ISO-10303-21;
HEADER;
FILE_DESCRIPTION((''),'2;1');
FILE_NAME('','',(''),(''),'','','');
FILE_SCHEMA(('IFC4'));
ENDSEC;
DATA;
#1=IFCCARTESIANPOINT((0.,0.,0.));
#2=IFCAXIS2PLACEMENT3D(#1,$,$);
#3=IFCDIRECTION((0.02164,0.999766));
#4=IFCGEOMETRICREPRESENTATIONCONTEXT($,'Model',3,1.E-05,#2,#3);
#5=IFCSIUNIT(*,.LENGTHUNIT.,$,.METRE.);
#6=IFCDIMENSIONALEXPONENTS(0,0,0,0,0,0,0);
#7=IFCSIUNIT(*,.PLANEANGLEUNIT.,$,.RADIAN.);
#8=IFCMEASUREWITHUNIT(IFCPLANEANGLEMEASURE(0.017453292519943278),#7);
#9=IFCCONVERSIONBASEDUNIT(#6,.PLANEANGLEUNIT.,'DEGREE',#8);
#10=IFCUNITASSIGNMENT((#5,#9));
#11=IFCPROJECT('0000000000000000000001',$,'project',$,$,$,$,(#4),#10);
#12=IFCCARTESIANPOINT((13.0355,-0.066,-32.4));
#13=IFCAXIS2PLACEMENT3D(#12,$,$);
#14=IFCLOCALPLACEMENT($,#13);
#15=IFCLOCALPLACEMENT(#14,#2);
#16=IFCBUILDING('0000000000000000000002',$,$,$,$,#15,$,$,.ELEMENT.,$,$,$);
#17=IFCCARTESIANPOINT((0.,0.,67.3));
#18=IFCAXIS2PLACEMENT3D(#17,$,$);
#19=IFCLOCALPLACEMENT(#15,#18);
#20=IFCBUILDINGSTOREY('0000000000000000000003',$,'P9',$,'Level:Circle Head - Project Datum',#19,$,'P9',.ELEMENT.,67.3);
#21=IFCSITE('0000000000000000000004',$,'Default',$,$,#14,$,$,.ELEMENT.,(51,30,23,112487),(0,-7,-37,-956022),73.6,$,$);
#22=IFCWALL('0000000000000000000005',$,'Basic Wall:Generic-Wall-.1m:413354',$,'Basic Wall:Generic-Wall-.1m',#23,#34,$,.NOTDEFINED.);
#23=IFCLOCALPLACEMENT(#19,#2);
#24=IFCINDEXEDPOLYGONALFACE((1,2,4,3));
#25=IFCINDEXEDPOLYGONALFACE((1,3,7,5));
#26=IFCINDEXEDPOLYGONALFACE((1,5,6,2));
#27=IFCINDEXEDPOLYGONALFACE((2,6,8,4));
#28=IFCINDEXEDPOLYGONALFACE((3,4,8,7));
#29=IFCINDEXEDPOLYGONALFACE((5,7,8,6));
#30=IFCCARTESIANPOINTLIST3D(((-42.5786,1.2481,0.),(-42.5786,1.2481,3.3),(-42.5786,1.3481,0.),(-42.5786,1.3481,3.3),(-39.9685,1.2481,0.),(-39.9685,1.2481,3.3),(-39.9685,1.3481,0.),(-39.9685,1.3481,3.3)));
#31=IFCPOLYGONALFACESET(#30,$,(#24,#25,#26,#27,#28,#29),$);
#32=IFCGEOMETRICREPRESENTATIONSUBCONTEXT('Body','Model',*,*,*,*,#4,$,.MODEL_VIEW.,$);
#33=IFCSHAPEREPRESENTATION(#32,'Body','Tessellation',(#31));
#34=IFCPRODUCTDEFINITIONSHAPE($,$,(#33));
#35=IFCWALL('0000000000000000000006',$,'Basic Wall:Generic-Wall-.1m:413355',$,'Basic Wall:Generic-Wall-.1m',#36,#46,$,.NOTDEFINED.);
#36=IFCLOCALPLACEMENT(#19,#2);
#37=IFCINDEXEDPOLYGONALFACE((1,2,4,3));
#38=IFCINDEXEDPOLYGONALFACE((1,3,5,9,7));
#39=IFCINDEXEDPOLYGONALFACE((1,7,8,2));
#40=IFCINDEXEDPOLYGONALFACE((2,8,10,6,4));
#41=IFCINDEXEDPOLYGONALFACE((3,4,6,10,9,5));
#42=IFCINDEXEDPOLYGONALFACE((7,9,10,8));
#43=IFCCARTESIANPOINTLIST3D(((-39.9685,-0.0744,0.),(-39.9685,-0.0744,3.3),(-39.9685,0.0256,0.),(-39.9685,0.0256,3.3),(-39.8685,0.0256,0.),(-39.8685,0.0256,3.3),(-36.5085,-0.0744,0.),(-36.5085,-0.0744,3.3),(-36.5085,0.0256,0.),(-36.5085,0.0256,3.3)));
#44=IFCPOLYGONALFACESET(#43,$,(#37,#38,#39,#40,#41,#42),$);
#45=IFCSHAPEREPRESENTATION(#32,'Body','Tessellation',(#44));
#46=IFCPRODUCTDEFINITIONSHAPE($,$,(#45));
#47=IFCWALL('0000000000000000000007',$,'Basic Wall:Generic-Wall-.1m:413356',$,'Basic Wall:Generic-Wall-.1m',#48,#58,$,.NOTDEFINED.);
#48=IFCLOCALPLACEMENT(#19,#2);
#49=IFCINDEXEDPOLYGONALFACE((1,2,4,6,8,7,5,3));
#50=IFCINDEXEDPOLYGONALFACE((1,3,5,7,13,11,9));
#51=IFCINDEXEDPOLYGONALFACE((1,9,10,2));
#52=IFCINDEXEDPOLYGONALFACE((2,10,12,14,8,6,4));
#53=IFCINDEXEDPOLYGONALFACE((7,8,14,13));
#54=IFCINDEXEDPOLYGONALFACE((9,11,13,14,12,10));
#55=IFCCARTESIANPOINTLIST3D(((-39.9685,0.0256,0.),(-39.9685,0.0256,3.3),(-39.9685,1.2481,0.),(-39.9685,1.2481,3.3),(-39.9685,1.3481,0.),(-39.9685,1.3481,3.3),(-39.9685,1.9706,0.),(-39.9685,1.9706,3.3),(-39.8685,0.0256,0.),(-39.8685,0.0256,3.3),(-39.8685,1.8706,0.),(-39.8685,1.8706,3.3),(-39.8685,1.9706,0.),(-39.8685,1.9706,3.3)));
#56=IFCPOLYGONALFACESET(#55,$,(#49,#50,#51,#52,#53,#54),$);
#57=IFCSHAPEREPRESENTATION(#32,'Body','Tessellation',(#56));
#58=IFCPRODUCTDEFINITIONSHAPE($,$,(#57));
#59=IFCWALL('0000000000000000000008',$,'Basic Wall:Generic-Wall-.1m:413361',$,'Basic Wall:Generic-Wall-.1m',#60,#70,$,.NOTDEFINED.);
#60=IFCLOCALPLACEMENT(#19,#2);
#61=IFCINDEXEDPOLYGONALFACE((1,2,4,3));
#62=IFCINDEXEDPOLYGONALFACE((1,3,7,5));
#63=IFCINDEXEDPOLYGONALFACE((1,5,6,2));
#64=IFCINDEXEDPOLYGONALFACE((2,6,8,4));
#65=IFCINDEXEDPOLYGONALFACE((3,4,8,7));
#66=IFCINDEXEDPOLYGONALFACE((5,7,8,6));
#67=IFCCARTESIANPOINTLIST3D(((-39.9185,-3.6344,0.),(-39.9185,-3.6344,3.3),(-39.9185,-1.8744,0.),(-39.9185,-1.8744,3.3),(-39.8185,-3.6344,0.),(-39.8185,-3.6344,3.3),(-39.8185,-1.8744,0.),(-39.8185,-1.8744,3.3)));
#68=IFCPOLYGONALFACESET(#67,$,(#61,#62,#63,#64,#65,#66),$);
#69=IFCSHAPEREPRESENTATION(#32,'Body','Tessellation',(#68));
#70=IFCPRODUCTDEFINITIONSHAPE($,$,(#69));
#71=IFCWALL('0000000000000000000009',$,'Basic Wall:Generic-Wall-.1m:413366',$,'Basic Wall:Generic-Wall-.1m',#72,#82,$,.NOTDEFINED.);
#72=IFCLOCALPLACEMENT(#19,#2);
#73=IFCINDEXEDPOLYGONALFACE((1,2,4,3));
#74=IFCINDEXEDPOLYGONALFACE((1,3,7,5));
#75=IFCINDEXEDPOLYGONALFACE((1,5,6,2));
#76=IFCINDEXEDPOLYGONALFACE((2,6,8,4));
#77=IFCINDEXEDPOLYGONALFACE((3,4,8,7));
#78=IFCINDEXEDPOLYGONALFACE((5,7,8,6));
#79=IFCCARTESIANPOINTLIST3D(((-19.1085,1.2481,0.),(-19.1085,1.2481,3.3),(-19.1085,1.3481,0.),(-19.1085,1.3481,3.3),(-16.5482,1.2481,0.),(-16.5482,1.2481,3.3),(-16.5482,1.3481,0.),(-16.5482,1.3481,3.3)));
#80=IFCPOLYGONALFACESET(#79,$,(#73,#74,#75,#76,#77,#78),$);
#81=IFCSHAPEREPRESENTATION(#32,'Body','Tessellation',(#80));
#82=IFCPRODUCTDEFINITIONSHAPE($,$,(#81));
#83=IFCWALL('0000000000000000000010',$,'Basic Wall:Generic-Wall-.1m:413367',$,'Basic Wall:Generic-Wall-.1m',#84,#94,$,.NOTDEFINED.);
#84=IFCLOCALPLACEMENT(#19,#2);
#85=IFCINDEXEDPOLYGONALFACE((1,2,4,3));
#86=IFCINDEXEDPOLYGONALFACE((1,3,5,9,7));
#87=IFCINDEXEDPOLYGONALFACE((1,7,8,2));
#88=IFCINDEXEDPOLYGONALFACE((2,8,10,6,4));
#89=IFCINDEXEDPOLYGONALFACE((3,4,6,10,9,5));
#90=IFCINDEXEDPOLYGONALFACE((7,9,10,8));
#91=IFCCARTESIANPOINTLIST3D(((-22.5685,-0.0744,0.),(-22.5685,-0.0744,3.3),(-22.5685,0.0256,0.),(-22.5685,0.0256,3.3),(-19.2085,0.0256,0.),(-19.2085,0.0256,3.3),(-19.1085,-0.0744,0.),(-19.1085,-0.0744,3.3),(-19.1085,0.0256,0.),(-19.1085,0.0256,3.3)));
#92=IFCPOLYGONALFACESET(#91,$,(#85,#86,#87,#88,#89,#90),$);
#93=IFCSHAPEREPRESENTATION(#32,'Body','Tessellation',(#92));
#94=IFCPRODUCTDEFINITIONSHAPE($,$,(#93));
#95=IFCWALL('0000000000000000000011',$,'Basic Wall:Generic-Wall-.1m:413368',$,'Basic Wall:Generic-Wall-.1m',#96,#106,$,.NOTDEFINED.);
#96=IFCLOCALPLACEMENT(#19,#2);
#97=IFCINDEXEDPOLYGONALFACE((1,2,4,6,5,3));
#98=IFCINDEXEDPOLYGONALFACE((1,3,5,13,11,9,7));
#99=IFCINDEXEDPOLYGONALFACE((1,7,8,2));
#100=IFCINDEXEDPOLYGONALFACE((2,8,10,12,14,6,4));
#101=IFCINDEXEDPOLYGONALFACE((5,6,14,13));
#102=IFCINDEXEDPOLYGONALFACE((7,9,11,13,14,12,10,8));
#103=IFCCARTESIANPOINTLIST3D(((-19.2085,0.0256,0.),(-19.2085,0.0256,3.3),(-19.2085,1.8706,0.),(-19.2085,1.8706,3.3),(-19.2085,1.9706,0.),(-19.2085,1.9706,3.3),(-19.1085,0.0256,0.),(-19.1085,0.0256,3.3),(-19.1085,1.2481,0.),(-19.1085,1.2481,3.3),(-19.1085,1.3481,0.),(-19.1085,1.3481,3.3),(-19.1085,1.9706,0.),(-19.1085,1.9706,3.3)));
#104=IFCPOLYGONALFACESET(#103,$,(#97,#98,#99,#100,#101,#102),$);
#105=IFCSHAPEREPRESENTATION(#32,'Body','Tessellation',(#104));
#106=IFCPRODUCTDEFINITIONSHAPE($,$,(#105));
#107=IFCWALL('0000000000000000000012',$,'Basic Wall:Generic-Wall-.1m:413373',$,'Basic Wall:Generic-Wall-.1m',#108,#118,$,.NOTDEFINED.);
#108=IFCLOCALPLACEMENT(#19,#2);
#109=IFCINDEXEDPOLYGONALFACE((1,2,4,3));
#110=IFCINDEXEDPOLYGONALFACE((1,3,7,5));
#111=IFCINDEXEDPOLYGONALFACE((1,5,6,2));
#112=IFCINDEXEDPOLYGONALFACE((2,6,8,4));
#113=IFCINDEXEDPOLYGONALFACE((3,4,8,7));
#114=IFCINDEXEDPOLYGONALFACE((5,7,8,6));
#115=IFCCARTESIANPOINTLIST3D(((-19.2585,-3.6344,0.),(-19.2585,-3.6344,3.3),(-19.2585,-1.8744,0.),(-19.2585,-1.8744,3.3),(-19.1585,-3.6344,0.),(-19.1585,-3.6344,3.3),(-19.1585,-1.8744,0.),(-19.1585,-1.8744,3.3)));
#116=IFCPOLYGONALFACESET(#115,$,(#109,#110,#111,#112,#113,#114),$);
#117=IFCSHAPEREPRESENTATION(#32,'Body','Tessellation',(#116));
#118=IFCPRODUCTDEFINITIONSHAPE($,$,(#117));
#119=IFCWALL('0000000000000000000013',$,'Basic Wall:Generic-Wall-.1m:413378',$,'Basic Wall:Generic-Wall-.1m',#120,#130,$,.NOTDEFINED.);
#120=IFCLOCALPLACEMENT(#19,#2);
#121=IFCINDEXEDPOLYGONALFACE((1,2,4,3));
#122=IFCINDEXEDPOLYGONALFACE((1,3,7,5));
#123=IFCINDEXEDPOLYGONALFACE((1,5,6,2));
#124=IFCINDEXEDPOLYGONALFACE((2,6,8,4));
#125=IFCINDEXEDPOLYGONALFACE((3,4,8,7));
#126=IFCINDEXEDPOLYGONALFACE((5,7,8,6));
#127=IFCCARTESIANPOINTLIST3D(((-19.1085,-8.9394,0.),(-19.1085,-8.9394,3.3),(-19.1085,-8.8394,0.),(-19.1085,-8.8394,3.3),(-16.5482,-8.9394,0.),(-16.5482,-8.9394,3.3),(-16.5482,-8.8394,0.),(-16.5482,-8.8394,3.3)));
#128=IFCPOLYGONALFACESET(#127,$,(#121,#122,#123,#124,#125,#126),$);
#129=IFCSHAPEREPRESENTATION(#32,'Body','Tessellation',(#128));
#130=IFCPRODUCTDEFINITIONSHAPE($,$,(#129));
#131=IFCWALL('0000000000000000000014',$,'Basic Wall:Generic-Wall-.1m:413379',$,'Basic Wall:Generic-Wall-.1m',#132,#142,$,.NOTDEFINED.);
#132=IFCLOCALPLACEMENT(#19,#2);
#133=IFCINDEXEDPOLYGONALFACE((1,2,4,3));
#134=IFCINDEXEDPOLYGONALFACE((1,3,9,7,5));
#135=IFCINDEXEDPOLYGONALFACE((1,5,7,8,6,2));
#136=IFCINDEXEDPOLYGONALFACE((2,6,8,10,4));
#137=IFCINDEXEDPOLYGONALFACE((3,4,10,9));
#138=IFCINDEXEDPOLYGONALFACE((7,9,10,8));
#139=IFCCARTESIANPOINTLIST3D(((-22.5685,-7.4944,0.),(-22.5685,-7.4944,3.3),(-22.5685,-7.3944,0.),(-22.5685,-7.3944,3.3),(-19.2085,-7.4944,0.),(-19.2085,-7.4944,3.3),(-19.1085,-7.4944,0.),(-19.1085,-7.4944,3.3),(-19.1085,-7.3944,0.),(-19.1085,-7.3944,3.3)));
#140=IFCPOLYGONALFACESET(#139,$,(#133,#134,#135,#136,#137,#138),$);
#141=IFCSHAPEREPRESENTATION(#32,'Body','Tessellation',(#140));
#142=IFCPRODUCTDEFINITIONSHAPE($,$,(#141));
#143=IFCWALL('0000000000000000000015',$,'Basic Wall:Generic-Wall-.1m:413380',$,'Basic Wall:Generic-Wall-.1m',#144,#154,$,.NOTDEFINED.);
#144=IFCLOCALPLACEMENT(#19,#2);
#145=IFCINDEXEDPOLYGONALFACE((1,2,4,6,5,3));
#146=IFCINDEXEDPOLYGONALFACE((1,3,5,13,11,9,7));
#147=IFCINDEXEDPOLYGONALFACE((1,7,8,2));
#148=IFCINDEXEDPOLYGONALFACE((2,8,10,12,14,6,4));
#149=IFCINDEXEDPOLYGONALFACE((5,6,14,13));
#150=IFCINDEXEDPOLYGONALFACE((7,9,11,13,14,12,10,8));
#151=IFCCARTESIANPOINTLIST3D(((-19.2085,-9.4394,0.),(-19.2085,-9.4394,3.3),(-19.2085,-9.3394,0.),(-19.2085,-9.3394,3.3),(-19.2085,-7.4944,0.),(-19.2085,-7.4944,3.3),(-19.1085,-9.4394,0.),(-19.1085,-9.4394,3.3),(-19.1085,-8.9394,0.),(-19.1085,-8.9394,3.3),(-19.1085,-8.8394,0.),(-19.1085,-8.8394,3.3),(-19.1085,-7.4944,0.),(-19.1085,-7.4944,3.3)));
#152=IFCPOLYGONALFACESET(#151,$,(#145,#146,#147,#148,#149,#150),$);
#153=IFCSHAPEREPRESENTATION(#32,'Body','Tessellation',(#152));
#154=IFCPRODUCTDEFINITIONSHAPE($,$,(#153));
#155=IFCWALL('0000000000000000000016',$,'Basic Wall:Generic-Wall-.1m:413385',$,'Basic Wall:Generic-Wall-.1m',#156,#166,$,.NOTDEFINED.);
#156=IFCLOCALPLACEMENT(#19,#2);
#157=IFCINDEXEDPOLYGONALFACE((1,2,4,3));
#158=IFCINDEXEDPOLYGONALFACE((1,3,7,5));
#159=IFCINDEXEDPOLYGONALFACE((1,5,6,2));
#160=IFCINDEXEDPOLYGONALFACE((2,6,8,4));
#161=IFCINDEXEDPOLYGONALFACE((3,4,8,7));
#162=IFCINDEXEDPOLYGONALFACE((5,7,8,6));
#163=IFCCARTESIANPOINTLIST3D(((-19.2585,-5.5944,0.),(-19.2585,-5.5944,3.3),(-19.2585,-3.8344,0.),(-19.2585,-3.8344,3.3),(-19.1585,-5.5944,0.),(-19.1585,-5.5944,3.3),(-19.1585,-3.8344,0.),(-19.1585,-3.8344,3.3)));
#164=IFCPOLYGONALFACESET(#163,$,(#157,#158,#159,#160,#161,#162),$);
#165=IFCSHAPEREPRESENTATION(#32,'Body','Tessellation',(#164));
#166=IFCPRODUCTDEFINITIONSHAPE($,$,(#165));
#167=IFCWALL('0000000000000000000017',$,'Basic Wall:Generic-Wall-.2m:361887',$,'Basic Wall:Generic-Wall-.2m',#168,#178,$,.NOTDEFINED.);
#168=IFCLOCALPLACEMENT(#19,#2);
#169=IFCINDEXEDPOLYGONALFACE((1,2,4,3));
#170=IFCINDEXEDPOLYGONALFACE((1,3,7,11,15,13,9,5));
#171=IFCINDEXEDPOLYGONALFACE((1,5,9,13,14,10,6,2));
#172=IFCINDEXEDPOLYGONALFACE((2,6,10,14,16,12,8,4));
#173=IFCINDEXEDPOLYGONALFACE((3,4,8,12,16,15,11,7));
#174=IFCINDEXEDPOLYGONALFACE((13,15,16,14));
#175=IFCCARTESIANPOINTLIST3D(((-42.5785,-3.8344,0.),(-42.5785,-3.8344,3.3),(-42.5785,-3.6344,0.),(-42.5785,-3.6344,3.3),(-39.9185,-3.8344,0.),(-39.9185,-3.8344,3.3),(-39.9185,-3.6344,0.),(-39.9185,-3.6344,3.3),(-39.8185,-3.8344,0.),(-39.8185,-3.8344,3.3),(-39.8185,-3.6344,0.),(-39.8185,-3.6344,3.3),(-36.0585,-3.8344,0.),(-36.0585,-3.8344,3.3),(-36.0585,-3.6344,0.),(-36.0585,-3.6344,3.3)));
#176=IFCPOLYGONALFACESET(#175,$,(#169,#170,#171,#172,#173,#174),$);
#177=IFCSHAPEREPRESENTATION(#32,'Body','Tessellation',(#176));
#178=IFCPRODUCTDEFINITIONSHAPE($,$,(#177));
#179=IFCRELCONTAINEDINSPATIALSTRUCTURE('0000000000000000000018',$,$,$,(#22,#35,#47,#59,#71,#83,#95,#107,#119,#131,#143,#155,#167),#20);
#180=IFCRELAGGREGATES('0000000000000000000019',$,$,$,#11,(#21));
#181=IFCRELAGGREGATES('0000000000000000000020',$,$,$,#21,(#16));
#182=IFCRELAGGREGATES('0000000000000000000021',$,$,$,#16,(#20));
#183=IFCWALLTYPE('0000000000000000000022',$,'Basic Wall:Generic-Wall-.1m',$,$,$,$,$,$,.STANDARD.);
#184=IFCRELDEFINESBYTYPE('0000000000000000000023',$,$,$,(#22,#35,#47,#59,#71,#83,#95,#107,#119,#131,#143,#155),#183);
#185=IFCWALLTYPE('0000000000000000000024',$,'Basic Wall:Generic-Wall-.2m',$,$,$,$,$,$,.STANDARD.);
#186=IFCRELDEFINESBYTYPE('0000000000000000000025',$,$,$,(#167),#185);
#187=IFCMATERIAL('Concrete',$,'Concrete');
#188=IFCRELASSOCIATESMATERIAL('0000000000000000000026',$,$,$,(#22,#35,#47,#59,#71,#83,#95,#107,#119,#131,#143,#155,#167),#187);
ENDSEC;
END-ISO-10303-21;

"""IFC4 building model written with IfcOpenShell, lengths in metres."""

from ifc_helpers import new_model, entity, si_unit, converted_unit, direction, frame, origin, place, context, subcontext, project, spatial, indexed_curve, outline, extrude, material, type_object, element, save


model = new_model("IFC4")

# Units and contexts
model_context = context("Model", 3, precision=1e-05, world=origin(), true_north=direction((0.02164, 0.999766)))
body_context = subcontext(model_context, "Body", "Model", "MODEL_VIEW")
ifc_project = project(units=[si_unit("LENGTHUNIT", "METRE"), converted_unit("PLANEANGLEUNIT", "DEGREE", entity("IfcPlaneAngleMeasure", 0.017453292519943278), si_unit("PLANEANGLEUNIT", "RADIAN"), dimensions=[0, 0, 0, 0, 0, 0, 0])], contexts=[model_context])

# Site, building, storey
site_placement = place(None, frame((13.0355, -0.066, -32.4)))
site = spatial("IfcSite", under=ifc_project, at=site_placement, Name="Default", CompositionType="ELEMENT", RefLatitude=(51, 30, 23, 112487), RefLongitude=(0, -7, -37, -956022), RefElevation=73.6)
building_placement = place(site_placement, origin())
building = spatial("IfcBuilding", under=site, at=building_placement, CompositionType="ELEMENT")
storey_placement = place(building_placement, frame((0.0, 0.0, 67.3)))
storey = spatial("IfcBuildingStorey", under=building, at=storey_placement, Name="P9", ObjectType="Level:Circle Head - Project Datum", LongName="P9", CompositionType="ELEMENT", Elevation=67.3)

# Shared definitions
ifc_material = material(Name="Concrete", Category="Concrete")

# Walls
wall_type_1 = type_object("IfcWallType", Name="Basic Wall:Generic-Wall-.1m", PredefinedType="STANDARD")
wall_1_placement = place(storey_placement, frame((-39.9685, 1.2981, 0.0), z_axis=(0.0, 0.0, 1.0), x_axis=(-1.0, 0.0, 0.0)))
element("IfcWall", 1, at=wall_1_placement, inside=storey, type_object=wall_type_1, material=ifc_material, Name="Basic Wall:Generic-Wall-.1m:413354", ObjectType="Basic Wall:Generic-Wall-.1m", PredefinedType="NOTDEFINED", context=body_context, shape_type="SweptSolid", body=[
    extrude(outline(indexed_curve([(2.6101, -0.05), (2.6101, 0.05), (0.0, 0.05), (0.0, -0.05), (2.6101, -0.05)], self_intersect=False)), origin(), (0.0, 0.0, 1.0), 3.3),
])
wall_2_placement = place(storey_placement, frame((-36.5085, -0.0244, 0.0), z_axis=(0.0, 0.0, 1.0), x_axis=(-1.0, 0.0, 0.0)))
element("IfcWall", 2, at=wall_2_placement, inside=storey, type_object=wall_type_1, material=ifc_material, Name="Basic Wall:Generic-Wall-.1m:413355", ObjectType="Basic Wall:Generic-Wall-.1m", PredefinedType="NOTDEFINED", context=body_context, shape_type="SweptSolid", body=[
    extrude(outline(indexed_curve([(3.46, -0.05), (3.46, 0.05), (0.0, 0.05), (0.0, -0.05), (3.36, -0.05), (3.46, -0.05)], self_intersect=False)), origin(), (0.0, 0.0, 1.0), 3.3),
])
wall_3_placement = place(storey_placement, frame((-39.9185, 0.0256, 0.0), z_axis=(0.0, 0.0, 1.0), x_axis=(0.0, 1.0, 0.0)))
element("IfcWall", 3, at=wall_3_placement, inside=storey, type_object=wall_type_1, material=ifc_material, Name="Basic Wall:Generic-Wall-.1m:413356", ObjectType="Basic Wall:Generic-Wall-.1m", PredefinedType="NOTDEFINED", context=body_context, shape_type="SweptSolid", body=[
    extrude(outline(indexed_curve([(1.945, -0.05), (1.945, 0.05), (1.3225, 0.05), (1.2225, 0.05), (0.0, 0.05), (0.0, -0.05), (1.845, -0.05), (1.945, -0.05)], self_intersect=False)), origin(), (0.0, 0.0, 1.0), 3.3),
])
wall_4_placement = place(storey_placement, frame((-39.8685, -1.8744, 0.0), z_axis=(0.0, 0.0, 1.0), x_axis=(0.0, -1.0, 0.0)))
element("IfcWall", 4, at=wall_4_placement, inside=storey, type_object=wall_type_1, material=ifc_material, Name="Basic Wall:Generic-Wall-.1m:413361", ObjectType="Basic Wall:Generic-Wall-.1m", PredefinedType="NOTDEFINED", context=body_context, shape_type="SweptSolid", body=[
    extrude(outline(indexed_curve([(1.76, -0.05), (1.76, 0.05), (0.0, 0.05), (0.0, -0.05), (1.76, -0.05)], self_intersect=False)), origin(), (0.0, 0.0, 1.0), 3.3),
])
wall_5_placement = place(storey_placement, frame((-19.1085, 1.2981, 0.0)))
element("IfcWall", 5, at=wall_5_placement, inside=storey, type_object=wall_type_1, material=ifc_material, Name="Basic Wall:Generic-Wall-.1m:413366", ObjectType="Basic Wall:Generic-Wall-.1m", PredefinedType="NOTDEFINED", context=body_context, shape_type="SweptSolid", body=[
    extrude(outline(indexed_curve([(2.5602, -0.05), (2.5602, 0.05), (0.0, 0.05), (0.0, -0.05), (2.5602, -0.05)], self_intersect=False)), origin(), (0.0, 0.0, 1.0), 3.3),
])
wall_6_placement = place(storey_placement, frame((-22.5685, -0.0244, 0.0)))
element("IfcWall", 6, at=wall_6_placement, inside=storey, type_object=wall_type_1, material=ifc_material, Name="Basic Wall:Generic-Wall-.1m:413367", ObjectType="Basic Wall:Generic-Wall-.1m", PredefinedType="NOTDEFINED", context=body_context, shape_type="SweptSolid", body=[
    extrude(outline(indexed_curve([(3.46, -0.05), (3.46, 0.05), (3.36, 0.05), (0.0, 0.05), (0.0, -0.05), (3.46, -0.05)], self_intersect=False)), origin(), (0.0, 0.0, 1.0), 3.3),
])
wall_7_placement = place(storey_placement, frame((-19.1585, 0.0256, 0.0), z_axis=(0.0, 0.0, 1.0), x_axis=(0.0, 1.0, 0.0)))
element("IfcWall", 7, at=wall_7_placement, inside=storey, type_object=wall_type_1, material=ifc_material, Name="Basic Wall:Generic-Wall-.1m:413368", ObjectType="Basic Wall:Generic-Wall-.1m", PredefinedType="NOTDEFINED", context=body_context, shape_type="SweptSolid", body=[
    extrude(outline(indexed_curve([(1.945, -0.05), (1.945, 0.05), (1.845, 0.05), (0.0, 0.05), (0.0, -0.05), (1.2225, -0.05), (1.3225, -0.05), (1.945, -0.05)], self_intersect=False)), origin(), (0.0, 0.0, 1.0), 3.3),
])
wall_8_placement = place(storey_placement, frame((-19.2085, -1.8744, 0.0), z_axis=(0.0, 0.0, 1.0), x_axis=(0.0, -1.0, 0.0)))
element("IfcWall", 8, at=wall_8_placement, inside=storey, type_object=wall_type_1, material=ifc_material, Name="Basic Wall:Generic-Wall-.1m:413373", ObjectType="Basic Wall:Generic-Wall-.1m", PredefinedType="NOTDEFINED", context=body_context, shape_type="SweptSolid", body=[
    extrude(outline(indexed_curve([(1.76, -0.05), (1.76, 0.05), (0.0, 0.05), (0.0, -0.05), (1.76, -0.05)], self_intersect=False)), origin(), (0.0, 0.0, 1.0), 3.3),
])
wall_9_placement = place(storey_placement, frame((-19.1085, -8.8894, 0.0)))
element("IfcWall", 9, at=wall_9_placement, inside=storey, type_object=wall_type_1, material=ifc_material, Name="Basic Wall:Generic-Wall-.1m:413378", ObjectType="Basic Wall:Generic-Wall-.1m", PredefinedType="NOTDEFINED", context=body_context, shape_type="SweptSolid", body=[
    extrude(outline(indexed_curve([(2.5602, -0.05), (2.5602, 0.05), (0.0, 0.05), (0.0, -0.05), (2.5602, -0.05)], self_intersect=False)), origin(), (0.0, 0.0, 1.0), 3.3),
])
wall_10_placement = place(storey_placement, frame((-22.5685, -7.4444, 0.0)))
element("IfcWall", 10, at=wall_10_placement, inside=storey, type_object=wall_type_1, material=ifc_material, Name="Basic Wall:Generic-Wall-.1m:413379", ObjectType="Basic Wall:Generic-Wall-.1m", PredefinedType="NOTDEFINED", context=body_context, shape_type="SweptSolid", body=[
    extrude(outline(indexed_curve([(3.46, -0.05), (3.46, 0.05), (0.0, 0.05), (0.0, -0.05), (3.36, -0.05), (3.46, -0.05)], self_intersect=False)), origin(), (0.0, 0.0, 1.0), 3.3),
])
wall_11_placement = place(storey_placement, frame((-19.1585, -7.4944, 0.0), z_axis=(0.0, 0.0, 1.0), x_axis=(0.0, -1.0, 0.0)))
element("IfcWall", 11, at=wall_11_placement, inside=storey, type_object=wall_type_1, material=ifc_material, Name="Basic Wall:Generic-Wall-.1m:413380", ObjectType="Basic Wall:Generic-Wall-.1m", PredefinedType="NOTDEFINED", context=body_context, shape_type="SweptSolid", body=[
    extrude(outline(indexed_curve([(1.945, -0.05), (1.945, 0.05), (1.445, 0.05), (1.345, 0.05), (0.0, 0.05), (0.0, -0.05), (1.845, -0.05), (1.945, -0.05)], self_intersect=False)), origin(), (0.0, 0.0, 1.0), 3.3),
])
wall_12_placement = place(storey_placement, frame((-19.2085, -5.5944, 0.0), z_axis=(0.0, 0.0, 1.0), x_axis=(0.0, 1.0, 0.0)))
element("IfcWall", 12, at=wall_12_placement, inside=storey, type_object=wall_type_1, material=ifc_material, Name="Basic Wall:Generic-Wall-.1m:413385", ObjectType="Basic Wall:Generic-Wall-.1m", PredefinedType="NOTDEFINED", context=body_context, shape_type="SweptSolid", body=[
    extrude(outline(indexed_curve([(1.76, -0.05), (1.76, 0.05), (0.0, 0.05), (0.0, -0.05), (1.76, -0.05)], self_intersect=False)), origin(), (0.0, 0.0, 1.0), 3.3),
])
wall_type_2 = type_object("IfcWallType", Name="Basic Wall:Generic-Wall-.2m", PredefinedType="STANDARD")
wall_13_placement = place(storey_placement, frame((-36.0585, -3.7344, 0.0), z_axis=(0.0, 0.0, 1.0), x_axis=(-1.0, 0.0, 0.0)))
element("IfcWall", 13, at=wall_13_placement, inside=storey, type_object=wall_type_2, material=ifc_material, Name="Basic Wall:Generic-Wall-.2m:361887", ObjectType="Basic Wall:Generic-Wall-.2m", PredefinedType="NOTDEFINED", context=body_context, shape_type="SweptSolid", body=[
    extrude(outline(indexed_curve([(6.52, -0.1), (6.52, 0.1), (3.86, 0.1), (3.76, 0.1), (0.0, 0.1), (0.0, -0.1), (3.76, -0.1), (3.86, -0.1), (6.52, -0.1)], self_intersect=False)), origin(), (0.0, 0.0, 1.0), 3.3),
])

save(model, "model.ifc")
